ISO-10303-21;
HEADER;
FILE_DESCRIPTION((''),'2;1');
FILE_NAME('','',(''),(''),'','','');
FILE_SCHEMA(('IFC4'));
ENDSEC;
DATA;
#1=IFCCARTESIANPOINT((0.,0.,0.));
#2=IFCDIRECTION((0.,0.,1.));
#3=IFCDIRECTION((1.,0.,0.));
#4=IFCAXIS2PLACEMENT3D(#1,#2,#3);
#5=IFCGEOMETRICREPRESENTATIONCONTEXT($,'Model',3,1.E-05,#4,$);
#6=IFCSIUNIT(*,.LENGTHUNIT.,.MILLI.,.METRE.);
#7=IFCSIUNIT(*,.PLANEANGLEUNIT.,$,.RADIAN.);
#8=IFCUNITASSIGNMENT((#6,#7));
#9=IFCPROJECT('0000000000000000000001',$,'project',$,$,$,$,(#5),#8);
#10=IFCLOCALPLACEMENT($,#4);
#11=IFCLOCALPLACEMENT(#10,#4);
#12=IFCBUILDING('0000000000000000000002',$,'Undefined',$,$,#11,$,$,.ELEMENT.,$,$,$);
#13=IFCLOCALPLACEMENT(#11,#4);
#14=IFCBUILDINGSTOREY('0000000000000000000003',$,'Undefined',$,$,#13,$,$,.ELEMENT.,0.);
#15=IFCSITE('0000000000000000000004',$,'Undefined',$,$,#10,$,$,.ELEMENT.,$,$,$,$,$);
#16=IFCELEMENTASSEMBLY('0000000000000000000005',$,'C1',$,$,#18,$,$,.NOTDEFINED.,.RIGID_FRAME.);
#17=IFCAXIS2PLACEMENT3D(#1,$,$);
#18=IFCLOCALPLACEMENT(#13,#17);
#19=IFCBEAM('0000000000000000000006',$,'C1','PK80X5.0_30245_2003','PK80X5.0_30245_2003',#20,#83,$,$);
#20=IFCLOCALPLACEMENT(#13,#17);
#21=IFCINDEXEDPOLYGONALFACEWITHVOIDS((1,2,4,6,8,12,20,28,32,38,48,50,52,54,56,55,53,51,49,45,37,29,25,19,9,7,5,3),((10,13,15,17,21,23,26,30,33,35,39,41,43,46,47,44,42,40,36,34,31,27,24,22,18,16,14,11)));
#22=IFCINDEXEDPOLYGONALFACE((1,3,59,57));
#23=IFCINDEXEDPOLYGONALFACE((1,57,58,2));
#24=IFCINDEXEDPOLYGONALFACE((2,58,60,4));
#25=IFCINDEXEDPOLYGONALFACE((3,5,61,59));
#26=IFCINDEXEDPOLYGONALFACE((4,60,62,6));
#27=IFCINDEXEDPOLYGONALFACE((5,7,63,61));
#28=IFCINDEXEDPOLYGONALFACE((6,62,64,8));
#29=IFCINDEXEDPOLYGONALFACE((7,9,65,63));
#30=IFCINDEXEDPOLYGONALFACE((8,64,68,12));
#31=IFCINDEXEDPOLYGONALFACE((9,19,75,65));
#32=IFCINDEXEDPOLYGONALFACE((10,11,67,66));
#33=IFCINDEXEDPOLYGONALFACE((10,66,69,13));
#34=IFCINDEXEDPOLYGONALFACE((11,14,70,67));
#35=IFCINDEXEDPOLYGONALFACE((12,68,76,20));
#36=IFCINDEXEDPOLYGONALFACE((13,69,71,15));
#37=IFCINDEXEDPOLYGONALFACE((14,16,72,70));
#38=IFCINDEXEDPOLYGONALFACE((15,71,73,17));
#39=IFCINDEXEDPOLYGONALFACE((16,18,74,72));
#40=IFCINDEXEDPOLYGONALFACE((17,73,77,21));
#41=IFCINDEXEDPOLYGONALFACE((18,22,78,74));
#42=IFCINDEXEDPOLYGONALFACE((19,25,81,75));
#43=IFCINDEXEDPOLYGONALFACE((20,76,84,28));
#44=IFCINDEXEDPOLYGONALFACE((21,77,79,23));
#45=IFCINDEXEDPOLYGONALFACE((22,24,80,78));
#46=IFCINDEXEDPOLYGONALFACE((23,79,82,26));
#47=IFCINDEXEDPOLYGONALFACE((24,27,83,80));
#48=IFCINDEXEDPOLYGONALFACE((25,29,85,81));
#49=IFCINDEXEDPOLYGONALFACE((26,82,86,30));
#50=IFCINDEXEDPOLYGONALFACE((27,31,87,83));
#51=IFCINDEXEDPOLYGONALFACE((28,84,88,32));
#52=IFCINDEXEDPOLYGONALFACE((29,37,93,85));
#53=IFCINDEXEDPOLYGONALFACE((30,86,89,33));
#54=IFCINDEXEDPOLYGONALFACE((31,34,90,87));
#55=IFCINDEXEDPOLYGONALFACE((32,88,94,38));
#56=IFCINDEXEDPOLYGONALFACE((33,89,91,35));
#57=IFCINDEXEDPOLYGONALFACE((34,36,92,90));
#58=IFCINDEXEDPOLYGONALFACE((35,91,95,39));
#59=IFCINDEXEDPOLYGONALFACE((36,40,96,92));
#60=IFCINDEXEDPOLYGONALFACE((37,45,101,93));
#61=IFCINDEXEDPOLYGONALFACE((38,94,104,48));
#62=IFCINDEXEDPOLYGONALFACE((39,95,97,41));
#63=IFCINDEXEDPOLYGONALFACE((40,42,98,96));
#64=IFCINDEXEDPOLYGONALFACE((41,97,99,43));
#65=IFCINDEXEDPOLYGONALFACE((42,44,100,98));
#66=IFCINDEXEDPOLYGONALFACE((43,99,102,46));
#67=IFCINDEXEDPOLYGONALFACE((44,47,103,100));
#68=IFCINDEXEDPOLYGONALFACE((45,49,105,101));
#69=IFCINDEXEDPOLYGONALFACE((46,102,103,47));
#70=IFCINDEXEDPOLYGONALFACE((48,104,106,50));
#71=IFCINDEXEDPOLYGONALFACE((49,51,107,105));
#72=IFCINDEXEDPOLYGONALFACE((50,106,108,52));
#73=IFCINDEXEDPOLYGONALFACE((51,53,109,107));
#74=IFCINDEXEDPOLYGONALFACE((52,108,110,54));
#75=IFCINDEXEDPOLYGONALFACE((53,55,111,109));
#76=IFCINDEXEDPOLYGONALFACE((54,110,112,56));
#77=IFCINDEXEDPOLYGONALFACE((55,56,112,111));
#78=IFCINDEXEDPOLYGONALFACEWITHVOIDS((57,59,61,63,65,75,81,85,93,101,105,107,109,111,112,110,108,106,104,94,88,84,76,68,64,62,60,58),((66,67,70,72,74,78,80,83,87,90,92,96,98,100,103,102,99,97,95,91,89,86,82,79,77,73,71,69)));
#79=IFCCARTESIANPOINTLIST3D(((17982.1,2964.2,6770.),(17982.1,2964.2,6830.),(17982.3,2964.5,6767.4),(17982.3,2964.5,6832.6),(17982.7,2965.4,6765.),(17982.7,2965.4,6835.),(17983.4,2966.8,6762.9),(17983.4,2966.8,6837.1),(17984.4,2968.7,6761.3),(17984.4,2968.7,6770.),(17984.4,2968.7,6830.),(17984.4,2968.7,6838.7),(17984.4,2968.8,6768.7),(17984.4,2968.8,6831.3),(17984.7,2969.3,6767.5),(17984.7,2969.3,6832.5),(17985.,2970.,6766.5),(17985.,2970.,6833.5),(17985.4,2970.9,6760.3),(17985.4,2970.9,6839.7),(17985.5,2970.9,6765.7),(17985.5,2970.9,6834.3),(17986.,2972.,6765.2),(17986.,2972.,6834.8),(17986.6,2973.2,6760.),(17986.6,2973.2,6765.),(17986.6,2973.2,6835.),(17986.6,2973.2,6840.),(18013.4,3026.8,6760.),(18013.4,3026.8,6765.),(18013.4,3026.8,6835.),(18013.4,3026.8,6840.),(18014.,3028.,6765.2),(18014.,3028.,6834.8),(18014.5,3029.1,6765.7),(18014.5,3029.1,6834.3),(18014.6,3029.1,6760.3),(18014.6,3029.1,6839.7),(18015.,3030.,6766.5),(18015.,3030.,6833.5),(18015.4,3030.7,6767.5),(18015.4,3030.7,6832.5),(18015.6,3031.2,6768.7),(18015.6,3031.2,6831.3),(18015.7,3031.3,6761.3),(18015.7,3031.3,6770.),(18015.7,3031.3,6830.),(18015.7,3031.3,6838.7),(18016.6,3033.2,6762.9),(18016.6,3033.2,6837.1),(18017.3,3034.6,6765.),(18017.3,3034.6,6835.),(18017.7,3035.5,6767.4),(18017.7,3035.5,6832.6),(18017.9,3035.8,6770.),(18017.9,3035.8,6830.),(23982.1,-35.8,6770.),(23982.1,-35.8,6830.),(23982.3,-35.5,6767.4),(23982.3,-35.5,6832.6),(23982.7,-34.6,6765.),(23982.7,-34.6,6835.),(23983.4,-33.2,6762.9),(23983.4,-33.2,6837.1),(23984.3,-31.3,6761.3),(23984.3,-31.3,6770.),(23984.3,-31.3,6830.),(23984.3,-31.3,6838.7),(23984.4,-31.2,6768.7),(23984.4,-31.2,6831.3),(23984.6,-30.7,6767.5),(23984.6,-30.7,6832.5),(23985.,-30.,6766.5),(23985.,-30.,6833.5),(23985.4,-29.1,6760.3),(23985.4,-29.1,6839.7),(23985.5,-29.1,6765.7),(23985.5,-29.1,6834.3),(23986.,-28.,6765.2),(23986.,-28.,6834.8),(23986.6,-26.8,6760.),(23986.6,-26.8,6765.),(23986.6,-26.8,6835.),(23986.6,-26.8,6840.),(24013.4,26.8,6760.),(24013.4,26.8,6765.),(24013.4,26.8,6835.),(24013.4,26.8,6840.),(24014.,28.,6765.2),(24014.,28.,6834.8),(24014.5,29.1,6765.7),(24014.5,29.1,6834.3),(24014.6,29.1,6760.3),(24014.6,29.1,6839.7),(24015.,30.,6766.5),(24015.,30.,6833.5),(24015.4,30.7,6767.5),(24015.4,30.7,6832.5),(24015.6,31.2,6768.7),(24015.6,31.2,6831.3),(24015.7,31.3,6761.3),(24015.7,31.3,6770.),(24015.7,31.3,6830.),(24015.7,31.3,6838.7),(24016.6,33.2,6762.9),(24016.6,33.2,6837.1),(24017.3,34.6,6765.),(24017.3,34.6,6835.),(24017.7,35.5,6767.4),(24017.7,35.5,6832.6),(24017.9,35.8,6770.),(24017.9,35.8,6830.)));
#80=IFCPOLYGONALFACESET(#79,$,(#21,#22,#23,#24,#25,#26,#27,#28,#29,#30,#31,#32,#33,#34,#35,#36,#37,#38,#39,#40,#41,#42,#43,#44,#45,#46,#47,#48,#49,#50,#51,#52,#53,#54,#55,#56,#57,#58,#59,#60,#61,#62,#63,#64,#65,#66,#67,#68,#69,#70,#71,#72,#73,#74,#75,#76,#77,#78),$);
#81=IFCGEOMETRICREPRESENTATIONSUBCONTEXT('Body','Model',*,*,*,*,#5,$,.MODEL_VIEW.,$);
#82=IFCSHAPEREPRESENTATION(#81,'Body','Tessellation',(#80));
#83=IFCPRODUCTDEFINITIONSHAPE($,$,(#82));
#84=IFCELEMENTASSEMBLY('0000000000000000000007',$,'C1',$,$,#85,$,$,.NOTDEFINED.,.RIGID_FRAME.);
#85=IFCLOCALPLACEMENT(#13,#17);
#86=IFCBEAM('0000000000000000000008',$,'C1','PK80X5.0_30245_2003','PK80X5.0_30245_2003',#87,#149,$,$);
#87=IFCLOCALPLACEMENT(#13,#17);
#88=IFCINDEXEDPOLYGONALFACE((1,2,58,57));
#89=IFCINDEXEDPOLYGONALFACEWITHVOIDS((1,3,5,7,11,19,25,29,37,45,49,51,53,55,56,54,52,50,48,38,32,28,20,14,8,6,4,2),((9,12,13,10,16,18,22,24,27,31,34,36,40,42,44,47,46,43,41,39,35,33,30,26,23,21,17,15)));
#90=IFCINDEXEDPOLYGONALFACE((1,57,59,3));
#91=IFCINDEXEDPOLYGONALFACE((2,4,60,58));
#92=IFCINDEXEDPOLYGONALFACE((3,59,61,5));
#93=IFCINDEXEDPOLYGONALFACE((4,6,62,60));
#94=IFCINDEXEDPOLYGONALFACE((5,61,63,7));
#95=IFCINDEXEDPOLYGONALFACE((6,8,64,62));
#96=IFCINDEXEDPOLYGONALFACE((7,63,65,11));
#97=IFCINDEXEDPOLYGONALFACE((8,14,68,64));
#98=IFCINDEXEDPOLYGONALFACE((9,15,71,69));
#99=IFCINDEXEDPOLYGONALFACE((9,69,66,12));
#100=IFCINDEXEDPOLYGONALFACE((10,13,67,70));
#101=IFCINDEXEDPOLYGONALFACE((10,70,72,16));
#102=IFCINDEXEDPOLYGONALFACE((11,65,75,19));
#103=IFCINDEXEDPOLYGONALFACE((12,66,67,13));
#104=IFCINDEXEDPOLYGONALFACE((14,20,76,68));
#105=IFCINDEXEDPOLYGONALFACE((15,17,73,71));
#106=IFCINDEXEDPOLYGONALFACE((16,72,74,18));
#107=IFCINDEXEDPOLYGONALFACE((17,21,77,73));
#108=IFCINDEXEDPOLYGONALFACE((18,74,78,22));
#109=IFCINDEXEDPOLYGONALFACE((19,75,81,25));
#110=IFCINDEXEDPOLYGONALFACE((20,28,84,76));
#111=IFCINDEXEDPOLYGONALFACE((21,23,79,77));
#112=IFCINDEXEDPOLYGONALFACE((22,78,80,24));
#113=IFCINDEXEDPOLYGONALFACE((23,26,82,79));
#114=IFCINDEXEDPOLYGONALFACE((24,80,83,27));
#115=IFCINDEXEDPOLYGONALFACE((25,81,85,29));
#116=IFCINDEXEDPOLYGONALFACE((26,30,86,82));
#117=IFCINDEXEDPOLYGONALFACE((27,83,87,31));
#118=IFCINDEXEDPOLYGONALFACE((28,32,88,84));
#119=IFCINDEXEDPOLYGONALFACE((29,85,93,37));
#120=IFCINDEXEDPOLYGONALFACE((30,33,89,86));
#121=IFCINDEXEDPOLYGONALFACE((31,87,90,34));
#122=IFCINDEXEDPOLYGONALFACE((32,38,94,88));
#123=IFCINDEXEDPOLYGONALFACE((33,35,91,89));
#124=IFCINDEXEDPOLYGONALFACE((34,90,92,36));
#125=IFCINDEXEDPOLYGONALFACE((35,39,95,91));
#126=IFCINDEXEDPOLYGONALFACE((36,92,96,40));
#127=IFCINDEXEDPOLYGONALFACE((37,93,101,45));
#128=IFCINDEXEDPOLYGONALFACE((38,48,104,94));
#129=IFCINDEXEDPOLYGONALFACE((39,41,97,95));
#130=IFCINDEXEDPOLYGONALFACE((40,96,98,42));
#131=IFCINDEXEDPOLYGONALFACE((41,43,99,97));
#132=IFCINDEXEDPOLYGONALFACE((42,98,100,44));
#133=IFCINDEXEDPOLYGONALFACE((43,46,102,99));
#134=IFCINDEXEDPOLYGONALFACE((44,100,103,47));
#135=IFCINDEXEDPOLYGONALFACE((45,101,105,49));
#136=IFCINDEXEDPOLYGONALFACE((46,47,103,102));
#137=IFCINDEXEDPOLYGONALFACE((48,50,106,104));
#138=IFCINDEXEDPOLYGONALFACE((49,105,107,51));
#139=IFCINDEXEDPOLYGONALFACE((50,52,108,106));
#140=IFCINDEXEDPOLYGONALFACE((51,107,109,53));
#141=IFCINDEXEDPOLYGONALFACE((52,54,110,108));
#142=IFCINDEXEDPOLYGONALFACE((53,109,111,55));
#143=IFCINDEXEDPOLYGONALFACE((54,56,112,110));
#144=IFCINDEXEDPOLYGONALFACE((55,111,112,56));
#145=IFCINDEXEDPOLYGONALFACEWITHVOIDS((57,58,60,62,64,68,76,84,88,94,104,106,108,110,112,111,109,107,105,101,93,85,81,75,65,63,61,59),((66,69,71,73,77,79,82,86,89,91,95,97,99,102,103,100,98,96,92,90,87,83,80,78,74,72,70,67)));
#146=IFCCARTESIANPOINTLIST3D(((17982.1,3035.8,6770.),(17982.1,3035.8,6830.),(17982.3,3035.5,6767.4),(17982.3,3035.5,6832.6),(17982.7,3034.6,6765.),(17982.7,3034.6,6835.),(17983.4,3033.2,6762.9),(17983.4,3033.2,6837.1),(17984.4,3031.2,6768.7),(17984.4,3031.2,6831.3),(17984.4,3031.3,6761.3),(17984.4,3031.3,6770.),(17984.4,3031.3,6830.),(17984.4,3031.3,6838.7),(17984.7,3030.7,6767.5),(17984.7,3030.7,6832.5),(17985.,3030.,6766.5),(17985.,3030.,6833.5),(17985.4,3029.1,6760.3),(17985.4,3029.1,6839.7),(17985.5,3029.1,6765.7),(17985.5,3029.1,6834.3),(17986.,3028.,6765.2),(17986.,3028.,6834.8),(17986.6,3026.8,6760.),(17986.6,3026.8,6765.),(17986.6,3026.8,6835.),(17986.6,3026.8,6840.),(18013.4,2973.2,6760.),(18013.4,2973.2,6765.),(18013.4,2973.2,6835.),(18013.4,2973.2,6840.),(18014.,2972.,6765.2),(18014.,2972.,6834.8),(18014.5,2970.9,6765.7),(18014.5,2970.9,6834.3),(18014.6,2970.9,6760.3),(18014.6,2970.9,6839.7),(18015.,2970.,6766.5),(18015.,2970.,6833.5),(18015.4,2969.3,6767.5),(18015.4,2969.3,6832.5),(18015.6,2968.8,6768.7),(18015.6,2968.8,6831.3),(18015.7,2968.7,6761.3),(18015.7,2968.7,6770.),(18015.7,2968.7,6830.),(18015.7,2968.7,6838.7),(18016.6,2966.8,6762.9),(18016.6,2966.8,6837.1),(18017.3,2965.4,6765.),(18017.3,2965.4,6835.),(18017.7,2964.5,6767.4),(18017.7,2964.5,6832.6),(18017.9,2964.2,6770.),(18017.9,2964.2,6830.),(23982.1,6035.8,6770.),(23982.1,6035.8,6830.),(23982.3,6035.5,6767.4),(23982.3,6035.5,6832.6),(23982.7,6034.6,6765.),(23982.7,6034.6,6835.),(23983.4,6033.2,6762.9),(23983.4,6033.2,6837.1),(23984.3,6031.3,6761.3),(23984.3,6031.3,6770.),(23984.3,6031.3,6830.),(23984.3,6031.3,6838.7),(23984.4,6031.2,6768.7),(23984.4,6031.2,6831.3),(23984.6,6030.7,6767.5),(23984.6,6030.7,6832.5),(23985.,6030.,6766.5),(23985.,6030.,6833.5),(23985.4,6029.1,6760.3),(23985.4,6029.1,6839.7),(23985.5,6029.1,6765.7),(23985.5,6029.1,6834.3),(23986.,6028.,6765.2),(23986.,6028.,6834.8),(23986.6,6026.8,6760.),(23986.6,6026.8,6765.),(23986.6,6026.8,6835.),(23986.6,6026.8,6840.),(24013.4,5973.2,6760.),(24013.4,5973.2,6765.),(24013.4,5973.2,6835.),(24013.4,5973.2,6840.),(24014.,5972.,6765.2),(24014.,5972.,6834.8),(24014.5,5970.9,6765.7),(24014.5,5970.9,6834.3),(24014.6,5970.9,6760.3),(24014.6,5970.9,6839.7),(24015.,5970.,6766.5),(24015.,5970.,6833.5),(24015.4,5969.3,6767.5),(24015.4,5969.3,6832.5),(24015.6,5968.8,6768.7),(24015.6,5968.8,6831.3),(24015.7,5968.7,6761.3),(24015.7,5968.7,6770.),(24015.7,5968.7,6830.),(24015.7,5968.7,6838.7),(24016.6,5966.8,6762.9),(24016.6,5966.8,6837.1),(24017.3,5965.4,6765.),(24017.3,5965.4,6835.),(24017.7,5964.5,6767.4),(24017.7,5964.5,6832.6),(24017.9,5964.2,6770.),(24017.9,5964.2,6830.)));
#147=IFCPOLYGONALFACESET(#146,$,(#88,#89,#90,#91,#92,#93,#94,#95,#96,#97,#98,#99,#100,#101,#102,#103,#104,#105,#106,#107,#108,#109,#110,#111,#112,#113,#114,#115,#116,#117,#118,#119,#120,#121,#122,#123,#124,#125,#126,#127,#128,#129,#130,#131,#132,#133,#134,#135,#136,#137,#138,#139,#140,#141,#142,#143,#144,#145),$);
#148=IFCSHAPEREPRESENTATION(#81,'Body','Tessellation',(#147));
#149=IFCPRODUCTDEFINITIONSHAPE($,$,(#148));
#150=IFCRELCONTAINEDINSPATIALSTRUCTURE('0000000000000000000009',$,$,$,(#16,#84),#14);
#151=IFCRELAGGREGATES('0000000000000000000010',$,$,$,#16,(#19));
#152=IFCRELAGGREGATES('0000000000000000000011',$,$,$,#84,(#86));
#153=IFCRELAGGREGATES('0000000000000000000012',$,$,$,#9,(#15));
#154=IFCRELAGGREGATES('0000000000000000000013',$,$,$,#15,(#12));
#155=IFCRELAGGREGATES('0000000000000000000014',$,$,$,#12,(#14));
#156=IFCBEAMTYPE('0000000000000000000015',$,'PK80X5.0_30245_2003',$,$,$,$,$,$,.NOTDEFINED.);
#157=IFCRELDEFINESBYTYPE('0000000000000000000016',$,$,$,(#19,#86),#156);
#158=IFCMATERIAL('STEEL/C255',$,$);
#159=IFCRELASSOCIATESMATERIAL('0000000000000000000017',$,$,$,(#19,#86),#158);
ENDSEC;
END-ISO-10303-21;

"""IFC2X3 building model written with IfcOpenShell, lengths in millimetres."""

from ifc_helpers import new_model, si_unit, frame, origin_with_axes, origin_2d_with_axis, place, context, subcontext, project, spatial, hollow_rectangle, extrude, material, type_object, element, aggregate, save


model = new_model("IFC2X3")

# Units and contexts
model_context = context("Model", 3, precision=1e-05, world=origin_with_axes())
body_context = subcontext(model_context, "Body", "Model", "MODEL_VIEW")
ifc_project = project(units=[si_unit("LENGTHUNIT", "METRE", prefix="MILLI"), si_unit("PLANEANGLEUNIT", "RADIAN")], contexts=[model_context])

# Site, building, storey
site_placement = place(None, origin_with_axes())
site = spatial("IfcSite", under=ifc_project, at=site_placement, Name="Undefined", CompositionType="ELEMENT")
building_placement = place(site_placement, origin_with_axes())
building = spatial("IfcBuilding", under=site, at=building_placement, Name="Undefined", CompositionType="ELEMENT")
storey_placement = place(building_placement, origin_with_axes())
storey = spatial("IfcBuildingStorey", under=building, at=storey_placement, Name="Undefined", CompositionType="ELEMENT", Elevation=0.0)

# Element assemblies, beams
assembly_1_placement = place(storey_placement, origin_with_axes())
assembly_1 = element("IfcElementAssembly", 1, at=assembly_1_placement, inside=storey, Name="C1", AssemblyPlace="NOTDEFINED", PredefinedType="RIGID_FRAME")
ifc_material_1 = material(Name="STEEL/C255")
beam_type_1 = type_object("IfcBeamType", Name="PK80X5.0_30245_2003", PredefinedType="NOTDEFINED")
beam_1_placement = place(assembly_1_placement, frame((18000.0, 3000.0, 6800.0), z_axis=(0.0, 0.0, -1.0), x_axis=(0.894427, -0.447214, 0.0)))
beam_1 = element("IfcBeam", 2, at=beam_1_placement, type_object=beam_type_1, material=ifc_material_1, Name="C1", Description="PK80X5.0_30245_2003", ObjectType="PK80X5.0_30245_2003", context=body_context, shape_type="SweptSolid", body=[
    extrude(hollow_rectangle(XDim=80.0, YDim=80.0, WallThickness=5.0, InnerFilletRadius=5.0, OuterFilletRadius=10.0, at=origin_2d_with_axis()), frame((6708.2, 0.0, 0.0), z_axis=(-1.0, 0.0, 0.0), x_axis=(0.0, -1.0, 0.0)), (0.0, 0.0, 1.0), 6708.2),
])
aggregate(assembly_1, [beam_1])
assembly_2_placement = place(storey_placement, origin_with_axes())
assembly_2 = element("IfcElementAssembly", 3, at=assembly_2_placement, inside=storey, Name="C1", AssemblyPlace="NOTDEFINED", PredefinedType="RIGID_FRAME")
beam_2_placement = place(assembly_2_placement, frame((18000.0, 3000.0, 6800.0), z_axis=(0.0, 0.0, -1.0), x_axis=(0.894427, 0.447214, 0.0)))
beam_2 = element("IfcBeam", 4, at=beam_2_placement, type_object=beam_type_1, material=ifc_material_1, Name="C1", Description="PK80X5.0_30245_2003", ObjectType="PK80X5.0_30245_2003", context=body_context, shape_type="SweptSolid", body=[
    extrude(hollow_rectangle(XDim=80.0, YDim=80.0, WallThickness=5.0, InnerFilletRadius=5.0, OuterFilletRadius=10.0, at=origin_2d_with_axis()), frame((6708.2, 0.0, 0.0), z_axis=(-1.0, 0.0, 0.0), x_axis=(0.0, -1.0, 0.0)), (0.0, 0.0, 1.0), 6708.2),
])
aggregate(assembly_2, [beam_2])

save(model, "model.ifc")
